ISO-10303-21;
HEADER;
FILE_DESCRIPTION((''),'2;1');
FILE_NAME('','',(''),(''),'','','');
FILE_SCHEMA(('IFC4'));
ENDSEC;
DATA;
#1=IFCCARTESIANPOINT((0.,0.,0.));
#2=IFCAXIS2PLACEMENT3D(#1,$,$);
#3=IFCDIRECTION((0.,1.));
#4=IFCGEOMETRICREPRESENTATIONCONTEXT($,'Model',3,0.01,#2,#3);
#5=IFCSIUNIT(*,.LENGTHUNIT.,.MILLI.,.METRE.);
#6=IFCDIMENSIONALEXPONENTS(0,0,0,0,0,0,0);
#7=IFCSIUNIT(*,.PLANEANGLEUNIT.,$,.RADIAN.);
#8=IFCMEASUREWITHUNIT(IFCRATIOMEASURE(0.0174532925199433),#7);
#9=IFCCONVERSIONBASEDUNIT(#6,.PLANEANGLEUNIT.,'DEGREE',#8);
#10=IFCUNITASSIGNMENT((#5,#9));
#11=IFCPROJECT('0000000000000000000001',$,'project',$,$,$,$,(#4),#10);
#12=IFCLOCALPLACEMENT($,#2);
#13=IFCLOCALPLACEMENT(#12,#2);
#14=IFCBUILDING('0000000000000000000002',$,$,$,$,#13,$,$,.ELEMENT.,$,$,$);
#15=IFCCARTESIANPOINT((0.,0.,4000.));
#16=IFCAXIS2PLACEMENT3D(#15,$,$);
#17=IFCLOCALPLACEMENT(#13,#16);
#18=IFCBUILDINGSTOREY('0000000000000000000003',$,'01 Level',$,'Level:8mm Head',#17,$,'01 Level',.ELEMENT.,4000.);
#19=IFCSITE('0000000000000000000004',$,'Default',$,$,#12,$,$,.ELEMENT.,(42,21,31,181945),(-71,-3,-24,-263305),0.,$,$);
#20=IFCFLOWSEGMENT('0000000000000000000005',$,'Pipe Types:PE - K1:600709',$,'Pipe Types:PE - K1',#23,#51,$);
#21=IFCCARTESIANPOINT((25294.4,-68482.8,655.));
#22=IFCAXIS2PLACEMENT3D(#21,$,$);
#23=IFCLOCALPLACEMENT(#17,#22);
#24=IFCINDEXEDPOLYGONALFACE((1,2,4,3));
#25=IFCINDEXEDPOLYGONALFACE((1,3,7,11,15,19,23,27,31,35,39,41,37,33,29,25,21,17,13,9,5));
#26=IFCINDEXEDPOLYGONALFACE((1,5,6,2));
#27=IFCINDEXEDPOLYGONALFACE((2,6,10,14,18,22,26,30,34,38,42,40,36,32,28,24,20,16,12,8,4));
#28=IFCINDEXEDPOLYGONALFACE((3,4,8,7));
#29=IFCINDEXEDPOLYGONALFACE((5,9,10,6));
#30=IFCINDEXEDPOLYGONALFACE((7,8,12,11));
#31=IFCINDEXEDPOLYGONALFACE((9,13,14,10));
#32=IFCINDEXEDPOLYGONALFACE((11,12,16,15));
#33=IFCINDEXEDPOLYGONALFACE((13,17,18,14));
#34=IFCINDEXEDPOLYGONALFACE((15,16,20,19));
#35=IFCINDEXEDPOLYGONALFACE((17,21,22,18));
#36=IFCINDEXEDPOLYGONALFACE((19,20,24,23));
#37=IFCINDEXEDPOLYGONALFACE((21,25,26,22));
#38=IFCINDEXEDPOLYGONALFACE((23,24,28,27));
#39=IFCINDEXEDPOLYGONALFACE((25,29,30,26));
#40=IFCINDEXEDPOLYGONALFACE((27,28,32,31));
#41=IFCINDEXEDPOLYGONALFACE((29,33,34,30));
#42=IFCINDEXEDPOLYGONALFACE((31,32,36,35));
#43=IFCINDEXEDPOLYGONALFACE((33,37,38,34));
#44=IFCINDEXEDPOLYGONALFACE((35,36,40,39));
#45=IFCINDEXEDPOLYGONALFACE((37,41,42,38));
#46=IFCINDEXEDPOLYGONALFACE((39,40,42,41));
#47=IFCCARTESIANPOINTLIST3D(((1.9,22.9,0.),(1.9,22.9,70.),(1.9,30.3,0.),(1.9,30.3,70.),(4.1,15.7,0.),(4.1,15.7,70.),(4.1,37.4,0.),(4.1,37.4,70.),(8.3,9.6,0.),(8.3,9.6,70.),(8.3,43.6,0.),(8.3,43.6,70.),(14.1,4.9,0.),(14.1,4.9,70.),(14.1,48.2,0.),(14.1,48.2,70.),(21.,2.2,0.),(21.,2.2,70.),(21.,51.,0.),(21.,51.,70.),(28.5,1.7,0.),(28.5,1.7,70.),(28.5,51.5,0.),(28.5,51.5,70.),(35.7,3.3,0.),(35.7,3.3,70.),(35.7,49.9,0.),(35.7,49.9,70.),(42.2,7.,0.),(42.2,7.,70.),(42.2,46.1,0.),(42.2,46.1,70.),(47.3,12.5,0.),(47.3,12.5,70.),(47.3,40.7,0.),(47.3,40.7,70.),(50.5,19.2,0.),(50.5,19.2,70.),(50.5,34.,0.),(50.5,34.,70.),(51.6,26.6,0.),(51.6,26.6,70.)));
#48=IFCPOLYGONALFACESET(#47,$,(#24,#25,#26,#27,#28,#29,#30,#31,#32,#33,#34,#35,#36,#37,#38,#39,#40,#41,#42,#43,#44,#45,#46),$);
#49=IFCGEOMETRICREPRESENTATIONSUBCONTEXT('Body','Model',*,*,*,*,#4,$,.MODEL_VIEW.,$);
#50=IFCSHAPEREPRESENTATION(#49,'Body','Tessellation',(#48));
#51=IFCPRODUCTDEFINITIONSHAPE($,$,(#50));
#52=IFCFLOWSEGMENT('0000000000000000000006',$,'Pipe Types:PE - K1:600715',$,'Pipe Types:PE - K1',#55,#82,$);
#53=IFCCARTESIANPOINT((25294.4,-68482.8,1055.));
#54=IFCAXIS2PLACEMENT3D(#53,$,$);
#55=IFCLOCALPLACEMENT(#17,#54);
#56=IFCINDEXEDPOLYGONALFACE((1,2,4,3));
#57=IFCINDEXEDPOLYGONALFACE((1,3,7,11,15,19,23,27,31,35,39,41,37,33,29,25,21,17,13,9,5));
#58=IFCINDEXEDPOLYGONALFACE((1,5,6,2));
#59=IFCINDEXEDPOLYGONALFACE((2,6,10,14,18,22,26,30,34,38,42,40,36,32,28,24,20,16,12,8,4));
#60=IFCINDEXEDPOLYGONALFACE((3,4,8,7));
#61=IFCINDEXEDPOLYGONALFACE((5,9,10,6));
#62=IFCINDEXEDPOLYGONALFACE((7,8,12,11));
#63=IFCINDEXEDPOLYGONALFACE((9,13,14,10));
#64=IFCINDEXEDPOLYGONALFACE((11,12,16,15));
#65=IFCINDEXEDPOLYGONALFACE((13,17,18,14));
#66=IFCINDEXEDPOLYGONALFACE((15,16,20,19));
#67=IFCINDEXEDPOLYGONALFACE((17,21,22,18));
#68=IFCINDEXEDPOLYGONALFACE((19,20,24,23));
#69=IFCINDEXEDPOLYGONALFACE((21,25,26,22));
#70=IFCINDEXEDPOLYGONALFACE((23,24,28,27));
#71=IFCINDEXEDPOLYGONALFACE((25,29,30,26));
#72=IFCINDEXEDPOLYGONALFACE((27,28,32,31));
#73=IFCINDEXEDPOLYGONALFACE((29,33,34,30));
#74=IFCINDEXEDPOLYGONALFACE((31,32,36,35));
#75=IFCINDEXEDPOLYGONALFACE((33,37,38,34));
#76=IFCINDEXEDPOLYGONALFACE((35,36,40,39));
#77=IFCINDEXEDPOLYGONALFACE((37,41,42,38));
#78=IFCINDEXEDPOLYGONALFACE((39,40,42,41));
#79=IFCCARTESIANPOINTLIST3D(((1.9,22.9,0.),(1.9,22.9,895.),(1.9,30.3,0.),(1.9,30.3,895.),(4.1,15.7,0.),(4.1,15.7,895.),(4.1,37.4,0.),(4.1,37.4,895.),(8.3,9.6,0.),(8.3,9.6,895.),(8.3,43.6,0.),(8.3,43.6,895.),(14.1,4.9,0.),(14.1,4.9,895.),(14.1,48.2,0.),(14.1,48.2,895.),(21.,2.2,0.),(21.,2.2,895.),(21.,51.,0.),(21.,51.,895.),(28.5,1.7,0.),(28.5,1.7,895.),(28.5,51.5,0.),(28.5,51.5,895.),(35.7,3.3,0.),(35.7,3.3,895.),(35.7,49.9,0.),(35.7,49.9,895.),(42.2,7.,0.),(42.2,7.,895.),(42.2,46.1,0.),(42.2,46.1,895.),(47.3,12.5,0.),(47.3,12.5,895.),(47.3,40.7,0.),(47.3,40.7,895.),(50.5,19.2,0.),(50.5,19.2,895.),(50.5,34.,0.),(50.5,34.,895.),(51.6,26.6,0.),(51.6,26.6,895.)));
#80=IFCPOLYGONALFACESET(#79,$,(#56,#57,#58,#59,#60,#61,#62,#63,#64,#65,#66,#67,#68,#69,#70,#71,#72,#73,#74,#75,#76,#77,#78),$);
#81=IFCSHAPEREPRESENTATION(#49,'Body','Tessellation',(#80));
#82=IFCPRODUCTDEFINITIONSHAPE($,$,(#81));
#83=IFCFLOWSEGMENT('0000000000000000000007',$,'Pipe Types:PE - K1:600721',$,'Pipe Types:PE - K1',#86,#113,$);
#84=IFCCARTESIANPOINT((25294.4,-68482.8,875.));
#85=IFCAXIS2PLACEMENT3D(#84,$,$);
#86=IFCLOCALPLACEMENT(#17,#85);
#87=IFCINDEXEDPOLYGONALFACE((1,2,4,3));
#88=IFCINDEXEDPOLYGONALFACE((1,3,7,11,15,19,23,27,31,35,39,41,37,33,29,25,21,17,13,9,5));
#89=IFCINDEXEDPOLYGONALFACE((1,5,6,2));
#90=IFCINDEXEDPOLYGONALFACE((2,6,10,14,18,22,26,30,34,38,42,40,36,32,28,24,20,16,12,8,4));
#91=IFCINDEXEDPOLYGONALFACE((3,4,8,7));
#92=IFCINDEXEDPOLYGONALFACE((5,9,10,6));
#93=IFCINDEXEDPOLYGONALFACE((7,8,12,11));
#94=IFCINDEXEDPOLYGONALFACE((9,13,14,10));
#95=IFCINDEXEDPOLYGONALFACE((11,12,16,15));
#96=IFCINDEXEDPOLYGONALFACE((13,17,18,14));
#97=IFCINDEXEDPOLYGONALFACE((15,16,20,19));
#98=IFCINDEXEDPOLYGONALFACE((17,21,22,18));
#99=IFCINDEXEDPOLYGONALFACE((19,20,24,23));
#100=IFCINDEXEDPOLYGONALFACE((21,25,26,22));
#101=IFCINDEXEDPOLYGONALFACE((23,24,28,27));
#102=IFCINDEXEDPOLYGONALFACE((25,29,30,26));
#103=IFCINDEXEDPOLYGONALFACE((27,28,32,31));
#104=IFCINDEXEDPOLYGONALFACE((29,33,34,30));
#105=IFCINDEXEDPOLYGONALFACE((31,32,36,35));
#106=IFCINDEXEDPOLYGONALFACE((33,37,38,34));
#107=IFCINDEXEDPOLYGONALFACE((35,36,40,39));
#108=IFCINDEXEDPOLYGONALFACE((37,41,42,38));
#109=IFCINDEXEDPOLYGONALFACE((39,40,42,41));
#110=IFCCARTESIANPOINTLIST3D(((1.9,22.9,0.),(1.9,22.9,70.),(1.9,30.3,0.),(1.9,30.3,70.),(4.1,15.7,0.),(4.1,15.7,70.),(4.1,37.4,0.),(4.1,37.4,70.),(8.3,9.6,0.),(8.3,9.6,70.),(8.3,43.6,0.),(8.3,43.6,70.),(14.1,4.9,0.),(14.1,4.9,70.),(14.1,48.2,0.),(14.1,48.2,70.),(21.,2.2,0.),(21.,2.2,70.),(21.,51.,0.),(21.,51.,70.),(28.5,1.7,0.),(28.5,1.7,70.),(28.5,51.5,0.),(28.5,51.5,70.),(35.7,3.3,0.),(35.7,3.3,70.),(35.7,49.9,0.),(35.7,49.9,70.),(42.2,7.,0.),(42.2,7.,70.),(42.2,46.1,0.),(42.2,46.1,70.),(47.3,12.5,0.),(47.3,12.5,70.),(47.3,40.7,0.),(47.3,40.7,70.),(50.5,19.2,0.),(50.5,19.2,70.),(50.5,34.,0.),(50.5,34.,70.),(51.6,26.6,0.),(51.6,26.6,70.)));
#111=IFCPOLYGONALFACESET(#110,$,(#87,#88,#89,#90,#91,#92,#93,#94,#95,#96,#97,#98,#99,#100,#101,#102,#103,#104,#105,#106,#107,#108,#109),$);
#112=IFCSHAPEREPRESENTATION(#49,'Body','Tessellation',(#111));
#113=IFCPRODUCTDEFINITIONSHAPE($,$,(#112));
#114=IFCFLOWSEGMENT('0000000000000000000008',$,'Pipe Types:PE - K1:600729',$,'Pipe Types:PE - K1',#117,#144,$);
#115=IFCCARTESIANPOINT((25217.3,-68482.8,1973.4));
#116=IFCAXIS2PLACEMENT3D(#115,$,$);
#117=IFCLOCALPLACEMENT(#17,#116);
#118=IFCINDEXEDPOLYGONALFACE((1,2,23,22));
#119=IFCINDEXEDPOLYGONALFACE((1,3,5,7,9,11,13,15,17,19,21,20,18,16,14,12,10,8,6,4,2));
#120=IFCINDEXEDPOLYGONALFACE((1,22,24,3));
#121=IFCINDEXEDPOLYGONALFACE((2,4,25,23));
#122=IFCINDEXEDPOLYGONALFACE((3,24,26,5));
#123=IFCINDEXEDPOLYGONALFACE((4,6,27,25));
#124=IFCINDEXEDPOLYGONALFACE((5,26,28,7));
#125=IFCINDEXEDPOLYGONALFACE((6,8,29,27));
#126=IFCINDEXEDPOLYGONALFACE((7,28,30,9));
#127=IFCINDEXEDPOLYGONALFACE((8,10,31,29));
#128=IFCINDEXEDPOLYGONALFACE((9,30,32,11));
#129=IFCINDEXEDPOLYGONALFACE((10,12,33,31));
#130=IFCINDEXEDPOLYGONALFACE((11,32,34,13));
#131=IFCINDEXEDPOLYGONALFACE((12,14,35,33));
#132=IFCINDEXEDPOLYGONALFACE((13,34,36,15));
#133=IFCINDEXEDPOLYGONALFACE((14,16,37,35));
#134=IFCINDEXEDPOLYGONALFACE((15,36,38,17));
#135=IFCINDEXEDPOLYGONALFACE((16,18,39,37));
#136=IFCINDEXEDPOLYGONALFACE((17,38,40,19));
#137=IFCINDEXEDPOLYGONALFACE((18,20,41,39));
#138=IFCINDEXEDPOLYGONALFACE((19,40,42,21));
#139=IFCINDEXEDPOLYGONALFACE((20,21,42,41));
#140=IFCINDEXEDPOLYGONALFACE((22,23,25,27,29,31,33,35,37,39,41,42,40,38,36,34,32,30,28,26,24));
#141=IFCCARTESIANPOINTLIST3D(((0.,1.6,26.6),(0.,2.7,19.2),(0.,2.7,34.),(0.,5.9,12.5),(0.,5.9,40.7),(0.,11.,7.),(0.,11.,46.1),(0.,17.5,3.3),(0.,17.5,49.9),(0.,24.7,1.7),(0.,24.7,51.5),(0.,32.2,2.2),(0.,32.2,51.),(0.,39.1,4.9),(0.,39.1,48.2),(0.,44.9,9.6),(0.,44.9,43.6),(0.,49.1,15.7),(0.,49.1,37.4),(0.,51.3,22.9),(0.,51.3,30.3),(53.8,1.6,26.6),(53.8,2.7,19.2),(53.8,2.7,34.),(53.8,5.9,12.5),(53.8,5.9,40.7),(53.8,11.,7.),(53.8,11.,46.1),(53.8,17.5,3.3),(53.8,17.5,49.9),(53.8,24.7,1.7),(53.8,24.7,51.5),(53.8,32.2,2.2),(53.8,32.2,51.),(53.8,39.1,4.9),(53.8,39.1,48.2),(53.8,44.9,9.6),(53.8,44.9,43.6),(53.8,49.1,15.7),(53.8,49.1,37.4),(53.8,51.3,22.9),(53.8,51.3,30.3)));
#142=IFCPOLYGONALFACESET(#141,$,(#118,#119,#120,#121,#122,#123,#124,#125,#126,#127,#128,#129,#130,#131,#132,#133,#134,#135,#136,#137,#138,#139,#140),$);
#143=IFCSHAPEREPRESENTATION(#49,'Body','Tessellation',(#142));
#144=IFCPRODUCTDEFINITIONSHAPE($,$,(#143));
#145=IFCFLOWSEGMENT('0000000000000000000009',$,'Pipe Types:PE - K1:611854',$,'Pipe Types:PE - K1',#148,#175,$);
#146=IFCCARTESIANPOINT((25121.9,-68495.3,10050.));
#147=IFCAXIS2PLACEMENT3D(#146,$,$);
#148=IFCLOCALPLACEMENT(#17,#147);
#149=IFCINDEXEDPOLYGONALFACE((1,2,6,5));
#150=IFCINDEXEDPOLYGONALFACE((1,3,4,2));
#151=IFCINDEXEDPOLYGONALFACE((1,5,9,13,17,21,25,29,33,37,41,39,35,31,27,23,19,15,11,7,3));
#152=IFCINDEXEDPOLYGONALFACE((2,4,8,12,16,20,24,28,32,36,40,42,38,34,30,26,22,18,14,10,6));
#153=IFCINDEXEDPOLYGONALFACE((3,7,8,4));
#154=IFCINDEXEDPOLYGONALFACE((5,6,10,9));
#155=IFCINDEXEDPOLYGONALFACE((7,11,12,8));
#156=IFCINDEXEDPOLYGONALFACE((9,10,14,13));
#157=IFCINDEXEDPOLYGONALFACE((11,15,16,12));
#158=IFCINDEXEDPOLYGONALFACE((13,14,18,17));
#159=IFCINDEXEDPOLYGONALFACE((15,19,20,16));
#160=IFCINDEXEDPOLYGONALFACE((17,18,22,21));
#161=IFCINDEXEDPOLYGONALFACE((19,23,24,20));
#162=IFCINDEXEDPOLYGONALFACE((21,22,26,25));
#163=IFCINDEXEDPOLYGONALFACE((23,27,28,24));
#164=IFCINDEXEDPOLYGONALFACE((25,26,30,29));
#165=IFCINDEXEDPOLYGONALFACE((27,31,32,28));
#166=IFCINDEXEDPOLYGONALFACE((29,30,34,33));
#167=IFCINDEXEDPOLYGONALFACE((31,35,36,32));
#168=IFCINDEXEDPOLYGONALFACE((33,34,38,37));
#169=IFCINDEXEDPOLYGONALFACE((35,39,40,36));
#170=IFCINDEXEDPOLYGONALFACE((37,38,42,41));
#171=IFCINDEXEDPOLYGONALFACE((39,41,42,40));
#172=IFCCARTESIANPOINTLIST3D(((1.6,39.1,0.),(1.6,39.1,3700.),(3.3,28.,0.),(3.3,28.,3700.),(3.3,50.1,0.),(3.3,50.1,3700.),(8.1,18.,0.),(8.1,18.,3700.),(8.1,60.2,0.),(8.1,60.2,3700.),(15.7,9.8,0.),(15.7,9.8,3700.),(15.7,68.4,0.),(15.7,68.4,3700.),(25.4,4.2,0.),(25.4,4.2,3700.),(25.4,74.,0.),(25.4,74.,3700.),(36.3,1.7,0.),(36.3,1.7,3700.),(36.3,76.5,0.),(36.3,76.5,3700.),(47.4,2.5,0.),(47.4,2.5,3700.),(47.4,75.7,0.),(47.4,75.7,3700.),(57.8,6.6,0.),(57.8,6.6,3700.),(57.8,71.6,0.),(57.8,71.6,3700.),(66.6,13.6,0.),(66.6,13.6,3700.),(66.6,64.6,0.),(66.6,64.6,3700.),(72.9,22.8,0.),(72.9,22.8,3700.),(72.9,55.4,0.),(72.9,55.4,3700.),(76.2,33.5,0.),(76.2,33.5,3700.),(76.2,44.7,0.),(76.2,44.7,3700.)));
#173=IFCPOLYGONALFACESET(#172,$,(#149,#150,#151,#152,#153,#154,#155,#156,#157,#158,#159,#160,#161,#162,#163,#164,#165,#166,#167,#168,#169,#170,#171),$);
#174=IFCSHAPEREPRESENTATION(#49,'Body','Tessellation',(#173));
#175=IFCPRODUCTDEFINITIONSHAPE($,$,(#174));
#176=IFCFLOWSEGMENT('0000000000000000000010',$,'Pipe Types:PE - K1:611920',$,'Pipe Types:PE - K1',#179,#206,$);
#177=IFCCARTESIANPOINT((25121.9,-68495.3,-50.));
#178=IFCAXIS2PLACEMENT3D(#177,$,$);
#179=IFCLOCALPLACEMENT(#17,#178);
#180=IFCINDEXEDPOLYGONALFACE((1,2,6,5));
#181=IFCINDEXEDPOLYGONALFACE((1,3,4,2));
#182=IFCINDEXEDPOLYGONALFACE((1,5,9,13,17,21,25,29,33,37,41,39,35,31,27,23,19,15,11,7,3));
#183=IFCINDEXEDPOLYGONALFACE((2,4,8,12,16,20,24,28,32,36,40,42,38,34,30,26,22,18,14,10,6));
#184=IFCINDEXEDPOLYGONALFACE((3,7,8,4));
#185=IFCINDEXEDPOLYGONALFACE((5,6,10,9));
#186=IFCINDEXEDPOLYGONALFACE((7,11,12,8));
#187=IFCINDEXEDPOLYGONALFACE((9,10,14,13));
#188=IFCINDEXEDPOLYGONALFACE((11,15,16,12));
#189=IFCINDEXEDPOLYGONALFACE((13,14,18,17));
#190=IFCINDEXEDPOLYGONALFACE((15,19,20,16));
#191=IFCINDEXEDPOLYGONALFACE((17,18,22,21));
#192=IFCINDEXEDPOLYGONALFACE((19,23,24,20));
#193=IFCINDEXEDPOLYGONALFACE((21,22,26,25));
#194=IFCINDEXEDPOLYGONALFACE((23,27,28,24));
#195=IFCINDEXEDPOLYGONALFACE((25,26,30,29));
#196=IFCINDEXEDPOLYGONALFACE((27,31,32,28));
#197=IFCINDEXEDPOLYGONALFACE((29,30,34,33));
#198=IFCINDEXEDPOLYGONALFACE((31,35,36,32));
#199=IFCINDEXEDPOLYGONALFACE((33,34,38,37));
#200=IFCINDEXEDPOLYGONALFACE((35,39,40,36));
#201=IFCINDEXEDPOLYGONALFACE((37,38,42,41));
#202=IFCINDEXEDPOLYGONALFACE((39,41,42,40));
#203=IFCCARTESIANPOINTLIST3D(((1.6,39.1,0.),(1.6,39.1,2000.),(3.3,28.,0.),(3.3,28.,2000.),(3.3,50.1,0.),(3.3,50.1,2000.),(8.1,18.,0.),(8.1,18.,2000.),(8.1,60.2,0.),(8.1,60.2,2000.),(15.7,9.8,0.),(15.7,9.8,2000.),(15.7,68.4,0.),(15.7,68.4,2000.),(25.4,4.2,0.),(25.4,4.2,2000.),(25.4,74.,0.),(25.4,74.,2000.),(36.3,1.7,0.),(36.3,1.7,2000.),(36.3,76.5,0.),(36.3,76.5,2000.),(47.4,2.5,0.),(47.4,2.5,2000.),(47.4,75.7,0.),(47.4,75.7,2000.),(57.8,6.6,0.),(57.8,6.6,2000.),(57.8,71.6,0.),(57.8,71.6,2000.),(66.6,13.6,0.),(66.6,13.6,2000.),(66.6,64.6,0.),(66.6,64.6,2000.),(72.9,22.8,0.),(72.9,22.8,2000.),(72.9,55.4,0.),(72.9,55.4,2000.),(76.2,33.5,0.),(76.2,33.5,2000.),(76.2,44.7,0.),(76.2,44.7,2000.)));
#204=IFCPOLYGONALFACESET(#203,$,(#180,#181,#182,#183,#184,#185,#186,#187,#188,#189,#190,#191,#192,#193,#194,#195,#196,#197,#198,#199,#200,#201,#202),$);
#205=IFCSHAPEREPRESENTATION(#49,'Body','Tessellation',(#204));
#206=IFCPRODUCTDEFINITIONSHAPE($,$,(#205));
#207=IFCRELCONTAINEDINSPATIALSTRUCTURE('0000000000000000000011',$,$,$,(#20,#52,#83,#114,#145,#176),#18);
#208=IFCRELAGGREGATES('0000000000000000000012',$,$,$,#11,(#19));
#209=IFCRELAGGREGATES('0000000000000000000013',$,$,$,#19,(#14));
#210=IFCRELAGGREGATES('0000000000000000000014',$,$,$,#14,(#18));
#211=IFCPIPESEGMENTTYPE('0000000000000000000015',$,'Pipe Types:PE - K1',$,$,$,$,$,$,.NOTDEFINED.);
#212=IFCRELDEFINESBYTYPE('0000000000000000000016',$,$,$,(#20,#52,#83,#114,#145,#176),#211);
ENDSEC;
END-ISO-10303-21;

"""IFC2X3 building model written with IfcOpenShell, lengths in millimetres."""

from ifc_helpers import new_model, entity, si_unit, converted_unit, direction, frame, frame_2d, origin, origin_2d_with_axis, place, context, subcontext, project, spatial, circle, extrude, type_object, element, save


model = new_model("IFC2X3")

# Units and contexts
model_context = context("Model", 3, precision=0.01, world=origin(), true_north=direction((0.0, 1.0)))
body_context = subcontext(model_context, "Body", "Model", "MODEL_VIEW")
ifc_project = project(units=[si_unit("LENGTHUNIT", "METRE", prefix="MILLI"), converted_unit("PLANEANGLEUNIT", "DEGREE", entity("IfcRatioMeasure", 0.0174532925199433), si_unit("PLANEANGLEUNIT", "RADIAN"), dimensions=[0, 0, 0, 0, 0, 0, 0])], contexts=[model_context])

# Site, building, storey
site_placement = place(None, origin())
site = spatial("IfcSite", under=ifc_project, at=site_placement, Name="Default", CompositionType="ELEMENT", RefLatitude=(42, 21, 31, 181945), RefLongitude=(-71, -3, -24, -263305), RefElevation=0.0)
building_placement = place(site_placement, origin())
building = spatial("IfcBuilding", under=site, at=building_placement, CompositionType="ELEMENT")
storey_placement = place(building_placement, frame((0.0, 0.0, 4000.0)))
storey = spatial("IfcBuildingStorey", under=building, at=storey_placement, Name="01 Level", ObjectType="Level:8mm Head", LongName="01 Level", CompositionType="ELEMENT", Elevation=4000.0)

# Flow segments
pipe_segment_type_1 = type_object("IfcPipeSegmentType", Name="Pipe Types:PE - K1", PredefinedType="NOTDEFINED")
flow_segment_1_placement = place(storey_placement, frame((25294.4, -68482.8, 655.0)))
element("IfcFlowSegment", 1, at=flow_segment_1_placement, inside=storey, type_object=pipe_segment_type_1, Name="Pipe Types:PE - K1:600709", ObjectType="Pipe Types:PE - K1", context=body_context, shape_type="SweptSolid", body=[
    extrude(circle(Radius=25.0, at=origin_2d_with_axis()), frame((26.6, 26.6, 0.0)), (0.0, 0.0, 1.0), 70.0),
])
flow_segment_2_placement = place(storey_placement, frame((25294.4, -68482.8, 1055.0)))
element("IfcFlowSegment", 2, at=flow_segment_2_placement, inside=storey, type_object=pipe_segment_type_1, Name="Pipe Types:PE - K1:600715", ObjectType="Pipe Types:PE - K1", context=body_context, shape_type="SweptSolid", body=[
    extrude(circle(Radius=25.0, at=frame_2d((0.0, 0.0), x_axis=(1.0, 0.0))), frame((26.6, 26.6, 0.0)), (0.0, 0.0, 1.0), 895.0),
])
flow_segment_3_placement = place(storey_placement, frame((25294.4, -68482.8, 875.0)))
element("IfcFlowSegment", 3, at=flow_segment_3_placement, inside=storey, type_object=pipe_segment_type_1, Name="Pipe Types:PE - K1:600721", ObjectType="Pipe Types:PE - K1", context=body_context, shape_type="SweptSolid", body=[
    extrude(circle(Radius=25.0, at=origin_2d_with_axis()), frame((26.6, 26.6, 0.0)), (0.0, 0.0, 1.0), 70.0),
])
flow_segment_4_placement = place(storey_placement, frame((25217.3, -68482.8, 1973.4)))
element("IfcFlowSegment", 4, at=flow_segment_4_placement, inside=storey, type_object=pipe_segment_type_1, Name="Pipe Types:PE - K1:600729", ObjectType="Pipe Types:PE - K1", context=body_context, shape_type="SweptSolid", body=[
    extrude(circle(Radius=25.0, at=frame_2d((0.0, 0.0), x_axis=(1.0, 0.0))), frame((0.0, 26.6, 26.6), z_axis=(1.0, 0.0, 0.0), x_axis=(0.0, -1.0, 0.0)), (0.0, 0.0, 1.0), 53.8),
])
flow_segment_5_placement = place(storey_placement, frame((25121.9, -68495.3, 10050.0)))
element("IfcFlowSegment", 5, at=flow_segment_5_placement, inside=storey, type_object=pipe_segment_type_1, Name="Pipe Types:PE - K1:611854", ObjectType="Pipe Types:PE - K1", context=body_context, shape_type="SweptSolid", body=[
    extrude(circle(Radius=37.5, at=origin_2d_with_axis()), frame((39.1, 39.1, 0.0), z_axis=(0.0, 0.0, 1.0), x_axis=(-1.0, 0.0, 0.0)), (0.0, 0.0, 1.0), 3700.0),
])
flow_segment_6_placement = place(storey_placement, frame((25121.9, -68495.3, -50.0)))
element("IfcFlowSegment", 6, at=flow_segment_6_placement, inside=storey, type_object=pipe_segment_type_1, Name="Pipe Types:PE - K1:611920", ObjectType="Pipe Types:PE - K1", context=body_context, shape_type="SweptSolid", body=[
    extrude(circle(Radius=37.5, at=origin_2d_with_axis()), frame((39.1, 39.1, 0.0), z_axis=(0.0, 0.0, 1.0), x_axis=(-1.0, 0.0, 0.0)), (0.0, 0.0, 1.0), 2000.0),
])

save(model, "model.ifc")
